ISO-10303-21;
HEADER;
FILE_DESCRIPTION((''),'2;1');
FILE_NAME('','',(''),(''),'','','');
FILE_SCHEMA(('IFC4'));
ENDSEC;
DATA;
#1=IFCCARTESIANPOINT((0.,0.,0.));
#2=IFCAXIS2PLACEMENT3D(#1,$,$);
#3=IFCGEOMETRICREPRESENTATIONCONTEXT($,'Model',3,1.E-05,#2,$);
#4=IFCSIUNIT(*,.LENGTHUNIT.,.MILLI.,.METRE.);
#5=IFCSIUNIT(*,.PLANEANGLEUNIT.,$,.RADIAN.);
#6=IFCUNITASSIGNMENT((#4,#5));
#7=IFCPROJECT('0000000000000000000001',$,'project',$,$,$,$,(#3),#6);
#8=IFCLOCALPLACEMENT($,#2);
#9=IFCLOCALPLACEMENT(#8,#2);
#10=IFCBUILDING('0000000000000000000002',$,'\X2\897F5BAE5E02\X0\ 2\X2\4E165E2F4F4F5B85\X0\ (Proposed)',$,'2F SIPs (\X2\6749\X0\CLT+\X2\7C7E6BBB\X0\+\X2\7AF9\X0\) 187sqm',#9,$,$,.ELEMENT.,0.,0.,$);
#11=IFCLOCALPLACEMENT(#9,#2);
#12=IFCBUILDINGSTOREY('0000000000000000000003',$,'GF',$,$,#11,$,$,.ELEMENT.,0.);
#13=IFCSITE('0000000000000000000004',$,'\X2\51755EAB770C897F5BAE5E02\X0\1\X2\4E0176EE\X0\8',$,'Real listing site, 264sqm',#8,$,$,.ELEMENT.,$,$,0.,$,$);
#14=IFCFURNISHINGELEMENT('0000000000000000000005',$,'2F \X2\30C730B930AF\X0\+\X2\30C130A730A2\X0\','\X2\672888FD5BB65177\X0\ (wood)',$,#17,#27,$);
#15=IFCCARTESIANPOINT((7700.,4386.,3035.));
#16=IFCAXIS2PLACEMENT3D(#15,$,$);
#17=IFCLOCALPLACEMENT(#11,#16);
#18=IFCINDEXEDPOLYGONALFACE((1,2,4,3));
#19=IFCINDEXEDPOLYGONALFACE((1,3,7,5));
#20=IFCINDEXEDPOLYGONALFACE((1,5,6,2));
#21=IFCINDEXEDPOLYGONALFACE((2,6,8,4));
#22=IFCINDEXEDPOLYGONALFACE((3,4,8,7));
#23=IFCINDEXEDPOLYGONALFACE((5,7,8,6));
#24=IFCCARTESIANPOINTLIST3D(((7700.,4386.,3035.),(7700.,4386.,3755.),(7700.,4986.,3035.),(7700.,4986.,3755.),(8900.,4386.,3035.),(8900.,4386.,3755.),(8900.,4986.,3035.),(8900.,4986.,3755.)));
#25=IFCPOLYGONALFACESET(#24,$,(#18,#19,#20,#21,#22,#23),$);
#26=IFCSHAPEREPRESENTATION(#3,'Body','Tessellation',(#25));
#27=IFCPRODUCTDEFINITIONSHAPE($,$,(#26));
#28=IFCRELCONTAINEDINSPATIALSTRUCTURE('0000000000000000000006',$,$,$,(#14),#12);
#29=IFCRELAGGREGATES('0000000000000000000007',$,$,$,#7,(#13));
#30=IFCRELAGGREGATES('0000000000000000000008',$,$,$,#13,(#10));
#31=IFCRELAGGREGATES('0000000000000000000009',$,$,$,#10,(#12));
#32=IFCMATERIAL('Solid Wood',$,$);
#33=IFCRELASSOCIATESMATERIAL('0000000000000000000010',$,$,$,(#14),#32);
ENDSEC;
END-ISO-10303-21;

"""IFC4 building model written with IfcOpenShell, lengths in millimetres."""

from ifc_helpers import new_model, si_unit, frame, frame_2d, origin, place, context, project, spatial, rectangle, extrude, material, element, save


model = new_model("IFC4")

# Units and contexts
model_context = context("Model", 3, precision=1e-05, world=origin())
ifc_project = project(units=[si_unit("LENGTHUNIT", "METRE", prefix="MILLI"), si_unit("PLANEANGLEUNIT", "RADIAN")], contexts=[model_context])

# Site, building, storey
site_placement = place(None, origin())
site = spatial("IfcSite", under=ifc_project, at=site_placement, Name="兵庫県西宮市1丁目8", ObjectType="Real listing site, 264sqm", CompositionType="ELEMENT", RefElevation=0.0)
building_placement = place(site_placement, origin())
building = spatial("IfcBuilding", under=site, at=building_placement, Name="西宮市 2世帯住宅 (Proposed)", ObjectType="2F SIPs (杉CLT+籾殻+竹) 187sqm", CompositionType="ELEMENT", ElevationOfRefHeight=0.0, ElevationOfTerrain=0.0)
storey_placement = place(building_placement, origin())
storey = spatial("IfcBuildingStorey", under=building, at=storey_placement, Name="GF", CompositionType="ELEMENT", Elevation=0.0)

# Shared definitions
ifc_material_1 = material(Name="Solid Wood")

# Furnishing element
furnishing_1_placement = place(storey_placement, frame((7700.0, 4386.0, 3035.0)))
element("IfcFurnishingElement", 1, at=furnishing_1_placement, inside=storey, material=ifc_material_1, Name="2F デスク+チェア", Description="木製家具 (wood)", context=model_context, shape_type="SweptSolid", body=[
    extrude(rectangle(XDim=1200.0, YDim=600.0, at=frame_2d((600.0, 300.0))), frame((7700.0, 4386.0, 3035.0)), (0.0, 0.0, 1.0), 720.0),
])

save(model, "model.ifc")
